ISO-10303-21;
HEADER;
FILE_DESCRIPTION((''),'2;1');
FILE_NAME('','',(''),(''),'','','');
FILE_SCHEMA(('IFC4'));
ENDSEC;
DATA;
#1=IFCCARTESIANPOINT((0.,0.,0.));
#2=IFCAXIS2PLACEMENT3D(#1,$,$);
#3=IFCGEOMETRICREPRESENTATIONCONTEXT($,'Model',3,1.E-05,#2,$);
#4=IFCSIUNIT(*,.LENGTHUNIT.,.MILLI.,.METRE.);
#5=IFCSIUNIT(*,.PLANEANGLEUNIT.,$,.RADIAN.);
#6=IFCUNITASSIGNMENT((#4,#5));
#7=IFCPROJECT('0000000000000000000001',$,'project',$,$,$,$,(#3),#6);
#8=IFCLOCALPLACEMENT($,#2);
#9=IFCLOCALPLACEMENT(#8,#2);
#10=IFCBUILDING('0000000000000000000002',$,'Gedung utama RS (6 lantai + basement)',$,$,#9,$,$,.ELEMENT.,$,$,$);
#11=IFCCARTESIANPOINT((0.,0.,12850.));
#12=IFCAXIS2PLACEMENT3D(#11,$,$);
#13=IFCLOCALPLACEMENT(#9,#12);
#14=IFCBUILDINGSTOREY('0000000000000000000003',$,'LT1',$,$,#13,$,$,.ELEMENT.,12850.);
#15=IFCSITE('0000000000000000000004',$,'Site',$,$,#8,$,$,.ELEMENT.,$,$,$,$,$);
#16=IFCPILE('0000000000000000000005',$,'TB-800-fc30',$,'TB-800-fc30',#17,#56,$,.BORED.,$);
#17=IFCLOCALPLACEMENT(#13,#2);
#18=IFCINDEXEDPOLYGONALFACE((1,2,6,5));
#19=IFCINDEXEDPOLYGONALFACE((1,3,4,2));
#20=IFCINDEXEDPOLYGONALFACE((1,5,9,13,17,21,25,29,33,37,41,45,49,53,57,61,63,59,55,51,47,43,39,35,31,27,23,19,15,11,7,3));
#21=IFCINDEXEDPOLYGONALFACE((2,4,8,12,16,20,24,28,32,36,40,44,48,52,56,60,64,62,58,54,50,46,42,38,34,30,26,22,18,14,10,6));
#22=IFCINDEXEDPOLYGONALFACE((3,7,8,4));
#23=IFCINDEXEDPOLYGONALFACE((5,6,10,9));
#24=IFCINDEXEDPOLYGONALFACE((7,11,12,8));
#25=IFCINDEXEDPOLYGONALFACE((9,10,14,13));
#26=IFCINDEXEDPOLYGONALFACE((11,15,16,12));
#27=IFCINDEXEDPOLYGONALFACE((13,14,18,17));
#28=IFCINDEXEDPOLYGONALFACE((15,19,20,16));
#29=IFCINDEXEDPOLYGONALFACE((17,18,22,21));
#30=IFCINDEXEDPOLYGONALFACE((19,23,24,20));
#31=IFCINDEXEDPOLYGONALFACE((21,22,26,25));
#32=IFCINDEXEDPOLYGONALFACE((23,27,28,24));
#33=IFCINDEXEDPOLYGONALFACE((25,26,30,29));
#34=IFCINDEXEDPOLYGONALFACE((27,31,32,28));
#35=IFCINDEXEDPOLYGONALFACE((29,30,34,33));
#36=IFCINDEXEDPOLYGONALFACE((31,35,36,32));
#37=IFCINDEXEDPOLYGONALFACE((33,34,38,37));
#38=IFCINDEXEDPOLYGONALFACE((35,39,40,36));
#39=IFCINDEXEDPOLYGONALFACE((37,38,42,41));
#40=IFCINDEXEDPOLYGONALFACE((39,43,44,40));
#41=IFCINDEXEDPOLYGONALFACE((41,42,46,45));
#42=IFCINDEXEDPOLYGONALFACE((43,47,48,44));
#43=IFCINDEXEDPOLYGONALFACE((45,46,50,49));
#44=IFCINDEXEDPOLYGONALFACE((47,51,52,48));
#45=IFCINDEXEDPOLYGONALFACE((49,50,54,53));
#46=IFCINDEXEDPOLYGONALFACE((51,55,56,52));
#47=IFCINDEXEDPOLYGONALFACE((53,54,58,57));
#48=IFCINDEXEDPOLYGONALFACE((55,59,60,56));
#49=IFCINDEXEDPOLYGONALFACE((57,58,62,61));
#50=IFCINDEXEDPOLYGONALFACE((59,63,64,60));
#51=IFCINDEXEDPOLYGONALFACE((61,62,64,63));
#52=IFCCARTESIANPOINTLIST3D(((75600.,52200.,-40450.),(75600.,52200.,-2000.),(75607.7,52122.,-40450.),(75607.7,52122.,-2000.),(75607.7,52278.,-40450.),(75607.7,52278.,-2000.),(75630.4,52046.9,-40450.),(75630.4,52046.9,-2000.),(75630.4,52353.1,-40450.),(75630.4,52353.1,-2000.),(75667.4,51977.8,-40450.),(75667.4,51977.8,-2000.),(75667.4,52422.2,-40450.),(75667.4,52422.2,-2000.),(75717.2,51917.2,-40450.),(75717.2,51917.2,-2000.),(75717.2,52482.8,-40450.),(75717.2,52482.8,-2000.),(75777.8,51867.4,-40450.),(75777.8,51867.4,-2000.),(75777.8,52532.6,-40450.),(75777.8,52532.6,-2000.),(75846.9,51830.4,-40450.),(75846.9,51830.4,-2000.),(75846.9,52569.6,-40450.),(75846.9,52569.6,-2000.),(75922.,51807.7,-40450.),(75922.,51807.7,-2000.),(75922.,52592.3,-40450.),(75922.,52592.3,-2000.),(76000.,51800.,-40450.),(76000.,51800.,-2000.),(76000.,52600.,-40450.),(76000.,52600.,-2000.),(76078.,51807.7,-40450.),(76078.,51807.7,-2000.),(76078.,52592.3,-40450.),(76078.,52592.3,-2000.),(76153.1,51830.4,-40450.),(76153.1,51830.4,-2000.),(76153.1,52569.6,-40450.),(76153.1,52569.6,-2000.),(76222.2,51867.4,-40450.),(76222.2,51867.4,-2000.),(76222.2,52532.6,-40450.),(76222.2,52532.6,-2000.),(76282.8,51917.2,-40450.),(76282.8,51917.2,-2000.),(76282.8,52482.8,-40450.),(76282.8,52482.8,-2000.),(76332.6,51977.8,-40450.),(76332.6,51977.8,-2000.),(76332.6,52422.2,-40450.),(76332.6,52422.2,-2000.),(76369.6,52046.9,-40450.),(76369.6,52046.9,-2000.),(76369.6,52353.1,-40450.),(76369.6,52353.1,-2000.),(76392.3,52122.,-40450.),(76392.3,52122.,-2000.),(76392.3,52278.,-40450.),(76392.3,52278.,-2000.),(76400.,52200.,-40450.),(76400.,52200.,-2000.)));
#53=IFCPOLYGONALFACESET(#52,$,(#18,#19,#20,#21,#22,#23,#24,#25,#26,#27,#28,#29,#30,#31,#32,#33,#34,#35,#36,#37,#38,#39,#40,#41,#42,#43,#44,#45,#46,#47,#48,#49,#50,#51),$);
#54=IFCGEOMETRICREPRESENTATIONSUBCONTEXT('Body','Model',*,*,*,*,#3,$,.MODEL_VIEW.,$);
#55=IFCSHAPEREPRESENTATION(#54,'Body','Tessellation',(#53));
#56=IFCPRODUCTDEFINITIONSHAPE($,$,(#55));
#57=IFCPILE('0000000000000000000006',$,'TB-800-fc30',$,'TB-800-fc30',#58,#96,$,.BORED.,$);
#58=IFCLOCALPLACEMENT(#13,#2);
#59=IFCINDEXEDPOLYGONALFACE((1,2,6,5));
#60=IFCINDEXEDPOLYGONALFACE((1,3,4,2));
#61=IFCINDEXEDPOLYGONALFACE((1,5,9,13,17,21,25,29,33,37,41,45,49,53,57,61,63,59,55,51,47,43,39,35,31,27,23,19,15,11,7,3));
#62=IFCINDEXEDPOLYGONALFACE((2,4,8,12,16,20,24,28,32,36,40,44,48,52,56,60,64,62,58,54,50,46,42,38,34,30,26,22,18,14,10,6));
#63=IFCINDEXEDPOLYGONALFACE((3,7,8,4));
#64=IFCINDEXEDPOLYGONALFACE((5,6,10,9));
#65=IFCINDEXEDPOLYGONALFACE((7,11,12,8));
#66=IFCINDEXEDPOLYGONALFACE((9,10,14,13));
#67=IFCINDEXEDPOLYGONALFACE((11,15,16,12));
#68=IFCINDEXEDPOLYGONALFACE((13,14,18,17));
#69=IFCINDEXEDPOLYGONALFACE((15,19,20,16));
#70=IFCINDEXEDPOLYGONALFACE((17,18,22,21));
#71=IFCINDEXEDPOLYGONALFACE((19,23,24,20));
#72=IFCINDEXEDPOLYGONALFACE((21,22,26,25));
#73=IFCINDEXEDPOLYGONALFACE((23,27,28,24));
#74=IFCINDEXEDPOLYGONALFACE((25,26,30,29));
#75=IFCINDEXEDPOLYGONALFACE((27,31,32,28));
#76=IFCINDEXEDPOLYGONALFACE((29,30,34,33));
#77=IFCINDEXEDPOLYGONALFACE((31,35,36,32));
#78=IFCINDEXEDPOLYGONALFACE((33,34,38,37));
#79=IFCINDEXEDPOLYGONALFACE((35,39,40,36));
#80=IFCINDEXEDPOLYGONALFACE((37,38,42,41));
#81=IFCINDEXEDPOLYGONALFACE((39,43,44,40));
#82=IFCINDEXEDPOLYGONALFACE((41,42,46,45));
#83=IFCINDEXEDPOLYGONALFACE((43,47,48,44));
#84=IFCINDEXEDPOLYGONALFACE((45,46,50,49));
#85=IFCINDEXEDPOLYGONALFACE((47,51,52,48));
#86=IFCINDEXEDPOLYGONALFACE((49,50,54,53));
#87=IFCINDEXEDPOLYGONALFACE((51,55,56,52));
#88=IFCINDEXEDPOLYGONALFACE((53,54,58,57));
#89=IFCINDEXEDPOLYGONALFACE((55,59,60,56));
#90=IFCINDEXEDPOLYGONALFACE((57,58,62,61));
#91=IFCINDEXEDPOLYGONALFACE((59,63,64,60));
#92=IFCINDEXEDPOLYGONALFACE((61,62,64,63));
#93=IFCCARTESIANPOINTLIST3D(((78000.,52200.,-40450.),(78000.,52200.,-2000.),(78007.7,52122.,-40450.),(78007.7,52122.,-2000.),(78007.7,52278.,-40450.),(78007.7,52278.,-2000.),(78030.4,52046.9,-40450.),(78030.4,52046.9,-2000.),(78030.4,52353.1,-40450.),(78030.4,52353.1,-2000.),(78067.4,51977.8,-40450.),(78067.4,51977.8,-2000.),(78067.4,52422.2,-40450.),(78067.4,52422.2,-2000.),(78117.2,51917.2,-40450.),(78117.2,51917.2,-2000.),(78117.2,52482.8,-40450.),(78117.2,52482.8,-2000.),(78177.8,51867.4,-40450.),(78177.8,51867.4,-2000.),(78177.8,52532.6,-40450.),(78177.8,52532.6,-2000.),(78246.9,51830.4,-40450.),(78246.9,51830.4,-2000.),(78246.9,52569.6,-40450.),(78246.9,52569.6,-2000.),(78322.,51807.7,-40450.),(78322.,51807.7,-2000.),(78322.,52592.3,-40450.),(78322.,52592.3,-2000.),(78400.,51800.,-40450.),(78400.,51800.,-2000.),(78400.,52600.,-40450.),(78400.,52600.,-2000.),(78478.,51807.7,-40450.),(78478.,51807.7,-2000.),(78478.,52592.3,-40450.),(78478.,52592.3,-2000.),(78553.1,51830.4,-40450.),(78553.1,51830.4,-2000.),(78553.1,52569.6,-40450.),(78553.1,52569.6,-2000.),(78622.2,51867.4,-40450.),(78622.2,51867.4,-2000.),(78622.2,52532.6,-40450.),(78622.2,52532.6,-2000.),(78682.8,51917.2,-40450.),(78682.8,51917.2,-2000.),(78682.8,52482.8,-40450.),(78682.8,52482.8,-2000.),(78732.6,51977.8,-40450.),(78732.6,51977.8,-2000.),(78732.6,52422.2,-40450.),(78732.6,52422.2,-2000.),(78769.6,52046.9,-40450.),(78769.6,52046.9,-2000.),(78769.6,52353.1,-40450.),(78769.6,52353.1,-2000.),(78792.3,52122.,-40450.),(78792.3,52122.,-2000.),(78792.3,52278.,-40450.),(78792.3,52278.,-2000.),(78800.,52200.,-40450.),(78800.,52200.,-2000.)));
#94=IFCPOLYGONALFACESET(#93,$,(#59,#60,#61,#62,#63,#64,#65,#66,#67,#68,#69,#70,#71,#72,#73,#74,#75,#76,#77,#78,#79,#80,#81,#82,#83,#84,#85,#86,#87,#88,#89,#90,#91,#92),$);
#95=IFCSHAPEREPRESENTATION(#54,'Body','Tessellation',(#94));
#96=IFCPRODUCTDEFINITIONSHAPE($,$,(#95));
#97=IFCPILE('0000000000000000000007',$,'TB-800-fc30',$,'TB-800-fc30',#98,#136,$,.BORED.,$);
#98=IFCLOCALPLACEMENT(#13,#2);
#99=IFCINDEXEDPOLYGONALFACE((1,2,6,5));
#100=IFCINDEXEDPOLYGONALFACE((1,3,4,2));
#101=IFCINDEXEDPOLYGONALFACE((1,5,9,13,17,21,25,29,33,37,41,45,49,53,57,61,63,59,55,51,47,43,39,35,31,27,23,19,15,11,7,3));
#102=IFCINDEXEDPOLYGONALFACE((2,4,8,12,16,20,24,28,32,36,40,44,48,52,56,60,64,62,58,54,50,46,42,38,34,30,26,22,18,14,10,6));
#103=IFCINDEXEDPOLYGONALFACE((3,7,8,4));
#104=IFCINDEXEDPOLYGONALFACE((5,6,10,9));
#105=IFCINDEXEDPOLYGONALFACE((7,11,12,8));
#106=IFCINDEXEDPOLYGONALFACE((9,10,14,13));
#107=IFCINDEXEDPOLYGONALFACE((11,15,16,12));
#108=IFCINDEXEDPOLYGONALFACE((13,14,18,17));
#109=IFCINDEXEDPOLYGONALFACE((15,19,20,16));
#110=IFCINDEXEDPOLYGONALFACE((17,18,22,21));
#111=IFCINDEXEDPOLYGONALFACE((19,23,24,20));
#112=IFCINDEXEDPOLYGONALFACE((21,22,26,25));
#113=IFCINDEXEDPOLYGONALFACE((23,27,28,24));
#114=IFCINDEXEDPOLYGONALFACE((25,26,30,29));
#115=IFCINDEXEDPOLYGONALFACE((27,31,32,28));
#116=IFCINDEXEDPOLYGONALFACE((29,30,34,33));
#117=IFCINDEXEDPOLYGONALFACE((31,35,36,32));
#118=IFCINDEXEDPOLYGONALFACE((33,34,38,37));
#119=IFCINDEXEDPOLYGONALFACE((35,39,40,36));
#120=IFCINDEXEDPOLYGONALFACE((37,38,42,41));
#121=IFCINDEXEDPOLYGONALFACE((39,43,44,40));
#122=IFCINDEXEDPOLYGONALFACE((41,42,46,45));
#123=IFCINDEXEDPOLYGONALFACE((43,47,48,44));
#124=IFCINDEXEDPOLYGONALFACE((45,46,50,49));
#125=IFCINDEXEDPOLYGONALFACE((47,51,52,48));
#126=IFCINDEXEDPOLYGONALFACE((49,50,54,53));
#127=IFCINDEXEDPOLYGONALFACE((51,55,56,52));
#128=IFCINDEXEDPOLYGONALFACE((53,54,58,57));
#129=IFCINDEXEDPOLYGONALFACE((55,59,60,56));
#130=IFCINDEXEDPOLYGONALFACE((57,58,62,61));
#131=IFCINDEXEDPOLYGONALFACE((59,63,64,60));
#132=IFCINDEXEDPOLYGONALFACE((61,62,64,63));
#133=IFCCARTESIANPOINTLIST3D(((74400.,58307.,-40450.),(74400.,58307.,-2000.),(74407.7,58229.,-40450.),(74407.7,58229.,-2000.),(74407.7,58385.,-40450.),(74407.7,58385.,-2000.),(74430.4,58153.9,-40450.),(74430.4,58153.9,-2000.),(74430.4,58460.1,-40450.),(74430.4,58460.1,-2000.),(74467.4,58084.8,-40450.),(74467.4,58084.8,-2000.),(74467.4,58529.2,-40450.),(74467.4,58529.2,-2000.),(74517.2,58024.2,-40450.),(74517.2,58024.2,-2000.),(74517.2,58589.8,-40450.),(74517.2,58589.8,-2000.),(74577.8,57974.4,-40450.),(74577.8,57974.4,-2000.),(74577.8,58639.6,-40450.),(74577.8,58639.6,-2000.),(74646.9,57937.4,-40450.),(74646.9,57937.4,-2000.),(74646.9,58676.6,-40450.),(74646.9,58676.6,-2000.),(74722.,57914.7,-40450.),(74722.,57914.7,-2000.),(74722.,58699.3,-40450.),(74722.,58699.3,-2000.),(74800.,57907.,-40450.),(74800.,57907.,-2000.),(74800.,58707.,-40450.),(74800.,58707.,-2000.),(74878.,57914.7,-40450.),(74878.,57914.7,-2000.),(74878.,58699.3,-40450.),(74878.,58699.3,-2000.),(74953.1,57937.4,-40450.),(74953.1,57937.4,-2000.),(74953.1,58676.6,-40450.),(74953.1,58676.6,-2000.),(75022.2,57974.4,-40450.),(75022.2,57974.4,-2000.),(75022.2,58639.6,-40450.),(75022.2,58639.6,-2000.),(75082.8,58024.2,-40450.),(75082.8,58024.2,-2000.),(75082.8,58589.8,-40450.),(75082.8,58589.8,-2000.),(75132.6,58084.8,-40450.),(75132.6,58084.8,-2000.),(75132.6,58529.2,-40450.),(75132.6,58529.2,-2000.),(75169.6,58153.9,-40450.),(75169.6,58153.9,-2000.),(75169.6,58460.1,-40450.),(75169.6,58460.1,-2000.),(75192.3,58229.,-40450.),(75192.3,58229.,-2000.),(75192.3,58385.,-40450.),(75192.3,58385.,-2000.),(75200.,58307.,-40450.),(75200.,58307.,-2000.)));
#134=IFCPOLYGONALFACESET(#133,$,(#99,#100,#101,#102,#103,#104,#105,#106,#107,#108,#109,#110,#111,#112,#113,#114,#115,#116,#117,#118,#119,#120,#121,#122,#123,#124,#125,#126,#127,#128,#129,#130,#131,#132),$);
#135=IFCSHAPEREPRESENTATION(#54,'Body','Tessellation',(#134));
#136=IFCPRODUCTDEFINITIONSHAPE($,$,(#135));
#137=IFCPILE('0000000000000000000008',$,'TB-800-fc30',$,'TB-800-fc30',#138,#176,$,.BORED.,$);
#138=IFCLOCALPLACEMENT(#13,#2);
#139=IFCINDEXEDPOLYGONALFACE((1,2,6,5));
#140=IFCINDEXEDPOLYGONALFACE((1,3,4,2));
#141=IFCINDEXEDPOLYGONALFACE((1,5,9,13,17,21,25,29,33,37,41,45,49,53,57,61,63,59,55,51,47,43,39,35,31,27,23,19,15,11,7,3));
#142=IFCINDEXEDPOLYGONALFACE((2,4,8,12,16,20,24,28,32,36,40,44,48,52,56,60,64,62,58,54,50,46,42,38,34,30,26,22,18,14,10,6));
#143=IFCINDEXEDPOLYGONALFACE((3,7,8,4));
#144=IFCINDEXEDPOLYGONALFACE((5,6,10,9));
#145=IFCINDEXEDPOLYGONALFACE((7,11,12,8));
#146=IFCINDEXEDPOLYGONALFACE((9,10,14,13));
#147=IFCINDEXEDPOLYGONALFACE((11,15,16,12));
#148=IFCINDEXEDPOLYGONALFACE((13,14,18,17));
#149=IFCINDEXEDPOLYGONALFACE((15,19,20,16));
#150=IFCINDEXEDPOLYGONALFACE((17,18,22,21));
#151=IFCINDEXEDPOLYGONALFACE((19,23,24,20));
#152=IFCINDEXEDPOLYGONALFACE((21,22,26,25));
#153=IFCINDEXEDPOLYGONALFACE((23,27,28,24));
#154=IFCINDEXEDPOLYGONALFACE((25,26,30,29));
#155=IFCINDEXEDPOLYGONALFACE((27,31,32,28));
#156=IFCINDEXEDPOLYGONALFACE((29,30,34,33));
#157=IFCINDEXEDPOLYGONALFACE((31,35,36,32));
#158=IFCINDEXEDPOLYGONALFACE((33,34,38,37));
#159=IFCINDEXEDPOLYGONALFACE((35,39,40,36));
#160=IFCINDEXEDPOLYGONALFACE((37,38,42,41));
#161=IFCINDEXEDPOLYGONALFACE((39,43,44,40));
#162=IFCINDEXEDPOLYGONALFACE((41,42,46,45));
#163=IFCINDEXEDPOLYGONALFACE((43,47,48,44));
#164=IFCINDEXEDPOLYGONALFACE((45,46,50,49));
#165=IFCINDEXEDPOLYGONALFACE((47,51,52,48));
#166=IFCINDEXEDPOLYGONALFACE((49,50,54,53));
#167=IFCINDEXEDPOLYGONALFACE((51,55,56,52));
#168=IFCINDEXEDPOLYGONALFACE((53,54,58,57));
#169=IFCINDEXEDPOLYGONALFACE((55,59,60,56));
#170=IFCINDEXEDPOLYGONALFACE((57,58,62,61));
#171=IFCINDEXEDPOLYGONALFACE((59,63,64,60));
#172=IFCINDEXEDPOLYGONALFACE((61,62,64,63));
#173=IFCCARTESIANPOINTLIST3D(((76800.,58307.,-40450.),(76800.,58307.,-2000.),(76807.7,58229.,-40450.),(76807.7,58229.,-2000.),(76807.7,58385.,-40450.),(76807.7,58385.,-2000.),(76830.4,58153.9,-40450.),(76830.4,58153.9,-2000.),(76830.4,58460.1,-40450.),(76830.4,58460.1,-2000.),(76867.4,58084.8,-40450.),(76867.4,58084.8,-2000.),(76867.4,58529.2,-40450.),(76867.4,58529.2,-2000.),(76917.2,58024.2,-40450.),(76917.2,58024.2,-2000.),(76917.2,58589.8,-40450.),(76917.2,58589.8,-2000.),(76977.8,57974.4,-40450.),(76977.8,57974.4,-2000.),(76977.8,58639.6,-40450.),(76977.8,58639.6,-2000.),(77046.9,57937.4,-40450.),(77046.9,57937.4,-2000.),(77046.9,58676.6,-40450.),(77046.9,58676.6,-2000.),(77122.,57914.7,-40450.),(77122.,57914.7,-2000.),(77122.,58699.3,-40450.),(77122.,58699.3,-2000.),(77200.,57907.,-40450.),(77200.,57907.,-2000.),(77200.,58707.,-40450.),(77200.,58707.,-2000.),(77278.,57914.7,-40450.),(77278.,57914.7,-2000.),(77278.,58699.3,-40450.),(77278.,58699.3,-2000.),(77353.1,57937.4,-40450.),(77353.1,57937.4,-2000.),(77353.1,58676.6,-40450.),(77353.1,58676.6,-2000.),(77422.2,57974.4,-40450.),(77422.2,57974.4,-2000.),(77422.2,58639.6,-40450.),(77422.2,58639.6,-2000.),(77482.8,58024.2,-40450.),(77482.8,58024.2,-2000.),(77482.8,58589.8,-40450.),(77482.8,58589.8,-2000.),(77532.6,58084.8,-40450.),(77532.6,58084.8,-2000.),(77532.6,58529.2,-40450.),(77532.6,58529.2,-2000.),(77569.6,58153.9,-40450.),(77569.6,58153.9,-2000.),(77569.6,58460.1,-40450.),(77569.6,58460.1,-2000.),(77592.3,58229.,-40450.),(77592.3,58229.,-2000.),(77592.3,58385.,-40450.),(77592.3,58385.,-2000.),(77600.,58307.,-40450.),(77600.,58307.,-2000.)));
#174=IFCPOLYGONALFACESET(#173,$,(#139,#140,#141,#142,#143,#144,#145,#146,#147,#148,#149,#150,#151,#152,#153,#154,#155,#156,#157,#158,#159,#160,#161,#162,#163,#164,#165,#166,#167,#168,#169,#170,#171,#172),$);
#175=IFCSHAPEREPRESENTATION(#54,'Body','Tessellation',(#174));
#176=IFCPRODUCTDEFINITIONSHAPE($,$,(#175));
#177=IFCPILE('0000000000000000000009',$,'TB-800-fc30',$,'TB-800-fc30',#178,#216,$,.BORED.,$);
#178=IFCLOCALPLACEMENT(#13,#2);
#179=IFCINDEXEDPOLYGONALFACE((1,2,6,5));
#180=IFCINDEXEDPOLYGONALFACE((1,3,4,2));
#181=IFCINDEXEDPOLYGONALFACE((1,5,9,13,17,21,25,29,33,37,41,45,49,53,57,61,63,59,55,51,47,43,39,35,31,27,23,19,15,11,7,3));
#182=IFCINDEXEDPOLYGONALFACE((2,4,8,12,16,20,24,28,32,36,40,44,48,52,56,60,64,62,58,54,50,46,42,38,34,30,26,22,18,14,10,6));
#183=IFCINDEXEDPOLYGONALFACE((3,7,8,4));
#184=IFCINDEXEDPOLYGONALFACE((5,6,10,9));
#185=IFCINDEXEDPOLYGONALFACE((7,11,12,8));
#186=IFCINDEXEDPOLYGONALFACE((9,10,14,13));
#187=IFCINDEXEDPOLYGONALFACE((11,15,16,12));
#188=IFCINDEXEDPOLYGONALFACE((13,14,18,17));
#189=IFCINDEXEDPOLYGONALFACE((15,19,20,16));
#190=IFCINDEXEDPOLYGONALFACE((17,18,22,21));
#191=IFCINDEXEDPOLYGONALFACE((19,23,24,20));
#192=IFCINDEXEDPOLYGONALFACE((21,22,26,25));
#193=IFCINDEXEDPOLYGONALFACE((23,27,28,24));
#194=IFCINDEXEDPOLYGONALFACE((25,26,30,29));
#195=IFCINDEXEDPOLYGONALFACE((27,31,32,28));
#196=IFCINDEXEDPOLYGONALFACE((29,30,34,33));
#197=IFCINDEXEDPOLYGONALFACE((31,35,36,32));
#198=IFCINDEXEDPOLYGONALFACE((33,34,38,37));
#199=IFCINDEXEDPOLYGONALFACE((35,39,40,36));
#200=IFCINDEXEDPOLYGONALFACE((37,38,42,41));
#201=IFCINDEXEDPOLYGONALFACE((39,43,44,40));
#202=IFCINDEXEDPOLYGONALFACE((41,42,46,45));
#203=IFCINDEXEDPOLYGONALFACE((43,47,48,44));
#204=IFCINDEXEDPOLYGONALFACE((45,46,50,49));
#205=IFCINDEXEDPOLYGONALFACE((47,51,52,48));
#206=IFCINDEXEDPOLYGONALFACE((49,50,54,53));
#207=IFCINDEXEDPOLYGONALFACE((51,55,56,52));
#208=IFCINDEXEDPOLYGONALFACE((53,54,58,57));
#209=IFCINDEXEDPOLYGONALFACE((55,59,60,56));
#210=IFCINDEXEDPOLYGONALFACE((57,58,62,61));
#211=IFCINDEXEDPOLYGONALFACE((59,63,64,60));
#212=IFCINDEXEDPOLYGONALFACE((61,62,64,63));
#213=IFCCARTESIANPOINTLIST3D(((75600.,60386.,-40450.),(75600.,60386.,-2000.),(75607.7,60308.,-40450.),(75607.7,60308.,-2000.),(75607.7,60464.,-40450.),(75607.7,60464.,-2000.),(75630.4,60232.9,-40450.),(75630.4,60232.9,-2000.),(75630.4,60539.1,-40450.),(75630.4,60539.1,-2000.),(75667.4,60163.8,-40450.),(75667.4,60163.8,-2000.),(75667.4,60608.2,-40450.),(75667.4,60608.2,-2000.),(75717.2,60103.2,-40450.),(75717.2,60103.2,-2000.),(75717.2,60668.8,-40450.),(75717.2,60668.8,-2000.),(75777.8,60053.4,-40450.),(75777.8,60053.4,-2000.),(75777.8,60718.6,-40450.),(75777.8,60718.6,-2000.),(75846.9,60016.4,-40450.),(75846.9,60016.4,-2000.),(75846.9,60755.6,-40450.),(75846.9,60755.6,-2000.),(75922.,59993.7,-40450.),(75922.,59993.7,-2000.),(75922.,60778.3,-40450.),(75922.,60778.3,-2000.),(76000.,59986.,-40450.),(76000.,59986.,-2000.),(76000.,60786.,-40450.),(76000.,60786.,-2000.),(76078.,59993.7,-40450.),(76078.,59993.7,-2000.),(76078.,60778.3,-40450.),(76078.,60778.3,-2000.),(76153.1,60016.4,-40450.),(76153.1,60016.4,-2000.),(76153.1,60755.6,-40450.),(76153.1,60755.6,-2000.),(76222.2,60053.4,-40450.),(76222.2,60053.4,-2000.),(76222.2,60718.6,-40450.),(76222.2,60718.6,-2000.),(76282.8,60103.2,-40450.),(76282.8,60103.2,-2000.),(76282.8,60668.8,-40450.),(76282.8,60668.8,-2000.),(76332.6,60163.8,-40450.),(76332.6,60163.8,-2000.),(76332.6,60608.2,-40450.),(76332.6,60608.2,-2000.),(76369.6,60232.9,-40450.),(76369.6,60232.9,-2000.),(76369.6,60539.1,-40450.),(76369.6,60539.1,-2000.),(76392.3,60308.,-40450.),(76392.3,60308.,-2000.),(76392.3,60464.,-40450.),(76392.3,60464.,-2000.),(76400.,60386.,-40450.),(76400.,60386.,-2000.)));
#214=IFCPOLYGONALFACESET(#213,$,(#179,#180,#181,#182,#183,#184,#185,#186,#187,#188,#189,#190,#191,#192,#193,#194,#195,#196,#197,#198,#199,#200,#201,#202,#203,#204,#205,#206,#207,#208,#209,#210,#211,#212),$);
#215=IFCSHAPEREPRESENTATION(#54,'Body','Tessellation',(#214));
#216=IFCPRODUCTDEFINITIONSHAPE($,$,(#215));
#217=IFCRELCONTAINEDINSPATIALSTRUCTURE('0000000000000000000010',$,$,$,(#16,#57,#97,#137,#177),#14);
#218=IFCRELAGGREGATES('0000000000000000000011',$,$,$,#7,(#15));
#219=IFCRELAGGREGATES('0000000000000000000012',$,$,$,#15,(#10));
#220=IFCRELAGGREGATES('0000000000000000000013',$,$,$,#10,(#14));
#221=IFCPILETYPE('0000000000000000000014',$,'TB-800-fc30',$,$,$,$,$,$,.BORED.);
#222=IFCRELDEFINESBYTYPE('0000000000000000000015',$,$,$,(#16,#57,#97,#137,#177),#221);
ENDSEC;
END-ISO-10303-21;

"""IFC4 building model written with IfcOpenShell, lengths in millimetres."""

from ifc_helpers import new_model, si_unit, frame, origin, origin_2d, place, context, subcontext, project, spatial, circle, extrude, material_profile, profile_set, profile_usage, type_object, element, save


model = new_model("IFC4")

# Units and contexts
model_context = context("Model", 3, precision=1e-05, world=origin())
body_context = subcontext(model_context, "Body", "Model", "MODEL_VIEW")
ifc_project = project(units=[si_unit("LENGTHUNIT", "METRE", prefix="MILLI"), si_unit("PLANEANGLEUNIT", "RADIAN")], contexts=[model_context])

# Site, building, storey
site_placement = place(None, origin())
site = spatial("IfcSite", under=ifc_project, at=site_placement, Name="Site", CompositionType="ELEMENT")
building_placement = place(site_placement, origin())
building = spatial("IfcBuilding", under=site, at=building_placement, Name="Gedung utama RS (6 lantai + basement)", CompositionType="ELEMENT")
storey_placement = place(building_placement, frame((0.0, 0.0, 12850.0)))
storey = spatial("IfcBuildingStorey", under=building, at=storey_placement, Name="LT1", CompositionType="ELEMENT", Elevation=12850.0)

# Piles
ifc_material_profile = material_profile(None, circle(Radius=400.0, at=origin_2d()), Name="TB-800-fc30")
ifc_profile_set = profile_set([ifc_material_profile], Name="TB-800-fc30")
ifc_profile_usage = profile_usage(ifc_profile_set, cardinal=5)
pile_type = type_object("IfcPileType", Name="TB-800-fc30", PredefinedType="BORED", material=ifc_profile_set)
for number, where, z_axis, x_axis, name in (
    (1, (76000.0, 52200.0, -40450.0), (0.0, 0.0, 1.0), (1.0, 0.0, 0.0), "TB-800-fc30"),
    (2, (78400.0, 52200.0, -40450.0), (0.0, 0.0, 1.0), (1.0, 0.0, 0.0), "TB-800-fc30"),
    (3, (74800.0, 58307.0, -40450.0), (0.0, 0.0, 1.0), (1.0, 0.0, 0.0), "TB-800-fc30"),
    (4, (77200.0, 58307.0, -40450.0), (0.0, 0.0, 1.0), (1.0, 0.0, 0.0), "TB-800-fc30"),
    (5, (76000.0, 60386.0, -40450.0), (0.0, 0.0, 1.0), (1.0, 0.0, 0.0), "TB-800-fc30"),
):
    element("IfcPile", number, at=place(storey_placement, frame(where, z_axis=z_axis, x_axis=x_axis)), inside=storey, type_object=pile_type, material=ifc_profile_usage, Name=name, ObjectType="TB-800-fc30", PredefinedType="BORED", context=body_context, shape_type="SweptSolid", body=[
        extrude(circle(Radius=400.0, at=origin_2d()), origin(), (0.0, 0.0, 1.0), 38450.0),
    ])

save(model, "model.ifc")
